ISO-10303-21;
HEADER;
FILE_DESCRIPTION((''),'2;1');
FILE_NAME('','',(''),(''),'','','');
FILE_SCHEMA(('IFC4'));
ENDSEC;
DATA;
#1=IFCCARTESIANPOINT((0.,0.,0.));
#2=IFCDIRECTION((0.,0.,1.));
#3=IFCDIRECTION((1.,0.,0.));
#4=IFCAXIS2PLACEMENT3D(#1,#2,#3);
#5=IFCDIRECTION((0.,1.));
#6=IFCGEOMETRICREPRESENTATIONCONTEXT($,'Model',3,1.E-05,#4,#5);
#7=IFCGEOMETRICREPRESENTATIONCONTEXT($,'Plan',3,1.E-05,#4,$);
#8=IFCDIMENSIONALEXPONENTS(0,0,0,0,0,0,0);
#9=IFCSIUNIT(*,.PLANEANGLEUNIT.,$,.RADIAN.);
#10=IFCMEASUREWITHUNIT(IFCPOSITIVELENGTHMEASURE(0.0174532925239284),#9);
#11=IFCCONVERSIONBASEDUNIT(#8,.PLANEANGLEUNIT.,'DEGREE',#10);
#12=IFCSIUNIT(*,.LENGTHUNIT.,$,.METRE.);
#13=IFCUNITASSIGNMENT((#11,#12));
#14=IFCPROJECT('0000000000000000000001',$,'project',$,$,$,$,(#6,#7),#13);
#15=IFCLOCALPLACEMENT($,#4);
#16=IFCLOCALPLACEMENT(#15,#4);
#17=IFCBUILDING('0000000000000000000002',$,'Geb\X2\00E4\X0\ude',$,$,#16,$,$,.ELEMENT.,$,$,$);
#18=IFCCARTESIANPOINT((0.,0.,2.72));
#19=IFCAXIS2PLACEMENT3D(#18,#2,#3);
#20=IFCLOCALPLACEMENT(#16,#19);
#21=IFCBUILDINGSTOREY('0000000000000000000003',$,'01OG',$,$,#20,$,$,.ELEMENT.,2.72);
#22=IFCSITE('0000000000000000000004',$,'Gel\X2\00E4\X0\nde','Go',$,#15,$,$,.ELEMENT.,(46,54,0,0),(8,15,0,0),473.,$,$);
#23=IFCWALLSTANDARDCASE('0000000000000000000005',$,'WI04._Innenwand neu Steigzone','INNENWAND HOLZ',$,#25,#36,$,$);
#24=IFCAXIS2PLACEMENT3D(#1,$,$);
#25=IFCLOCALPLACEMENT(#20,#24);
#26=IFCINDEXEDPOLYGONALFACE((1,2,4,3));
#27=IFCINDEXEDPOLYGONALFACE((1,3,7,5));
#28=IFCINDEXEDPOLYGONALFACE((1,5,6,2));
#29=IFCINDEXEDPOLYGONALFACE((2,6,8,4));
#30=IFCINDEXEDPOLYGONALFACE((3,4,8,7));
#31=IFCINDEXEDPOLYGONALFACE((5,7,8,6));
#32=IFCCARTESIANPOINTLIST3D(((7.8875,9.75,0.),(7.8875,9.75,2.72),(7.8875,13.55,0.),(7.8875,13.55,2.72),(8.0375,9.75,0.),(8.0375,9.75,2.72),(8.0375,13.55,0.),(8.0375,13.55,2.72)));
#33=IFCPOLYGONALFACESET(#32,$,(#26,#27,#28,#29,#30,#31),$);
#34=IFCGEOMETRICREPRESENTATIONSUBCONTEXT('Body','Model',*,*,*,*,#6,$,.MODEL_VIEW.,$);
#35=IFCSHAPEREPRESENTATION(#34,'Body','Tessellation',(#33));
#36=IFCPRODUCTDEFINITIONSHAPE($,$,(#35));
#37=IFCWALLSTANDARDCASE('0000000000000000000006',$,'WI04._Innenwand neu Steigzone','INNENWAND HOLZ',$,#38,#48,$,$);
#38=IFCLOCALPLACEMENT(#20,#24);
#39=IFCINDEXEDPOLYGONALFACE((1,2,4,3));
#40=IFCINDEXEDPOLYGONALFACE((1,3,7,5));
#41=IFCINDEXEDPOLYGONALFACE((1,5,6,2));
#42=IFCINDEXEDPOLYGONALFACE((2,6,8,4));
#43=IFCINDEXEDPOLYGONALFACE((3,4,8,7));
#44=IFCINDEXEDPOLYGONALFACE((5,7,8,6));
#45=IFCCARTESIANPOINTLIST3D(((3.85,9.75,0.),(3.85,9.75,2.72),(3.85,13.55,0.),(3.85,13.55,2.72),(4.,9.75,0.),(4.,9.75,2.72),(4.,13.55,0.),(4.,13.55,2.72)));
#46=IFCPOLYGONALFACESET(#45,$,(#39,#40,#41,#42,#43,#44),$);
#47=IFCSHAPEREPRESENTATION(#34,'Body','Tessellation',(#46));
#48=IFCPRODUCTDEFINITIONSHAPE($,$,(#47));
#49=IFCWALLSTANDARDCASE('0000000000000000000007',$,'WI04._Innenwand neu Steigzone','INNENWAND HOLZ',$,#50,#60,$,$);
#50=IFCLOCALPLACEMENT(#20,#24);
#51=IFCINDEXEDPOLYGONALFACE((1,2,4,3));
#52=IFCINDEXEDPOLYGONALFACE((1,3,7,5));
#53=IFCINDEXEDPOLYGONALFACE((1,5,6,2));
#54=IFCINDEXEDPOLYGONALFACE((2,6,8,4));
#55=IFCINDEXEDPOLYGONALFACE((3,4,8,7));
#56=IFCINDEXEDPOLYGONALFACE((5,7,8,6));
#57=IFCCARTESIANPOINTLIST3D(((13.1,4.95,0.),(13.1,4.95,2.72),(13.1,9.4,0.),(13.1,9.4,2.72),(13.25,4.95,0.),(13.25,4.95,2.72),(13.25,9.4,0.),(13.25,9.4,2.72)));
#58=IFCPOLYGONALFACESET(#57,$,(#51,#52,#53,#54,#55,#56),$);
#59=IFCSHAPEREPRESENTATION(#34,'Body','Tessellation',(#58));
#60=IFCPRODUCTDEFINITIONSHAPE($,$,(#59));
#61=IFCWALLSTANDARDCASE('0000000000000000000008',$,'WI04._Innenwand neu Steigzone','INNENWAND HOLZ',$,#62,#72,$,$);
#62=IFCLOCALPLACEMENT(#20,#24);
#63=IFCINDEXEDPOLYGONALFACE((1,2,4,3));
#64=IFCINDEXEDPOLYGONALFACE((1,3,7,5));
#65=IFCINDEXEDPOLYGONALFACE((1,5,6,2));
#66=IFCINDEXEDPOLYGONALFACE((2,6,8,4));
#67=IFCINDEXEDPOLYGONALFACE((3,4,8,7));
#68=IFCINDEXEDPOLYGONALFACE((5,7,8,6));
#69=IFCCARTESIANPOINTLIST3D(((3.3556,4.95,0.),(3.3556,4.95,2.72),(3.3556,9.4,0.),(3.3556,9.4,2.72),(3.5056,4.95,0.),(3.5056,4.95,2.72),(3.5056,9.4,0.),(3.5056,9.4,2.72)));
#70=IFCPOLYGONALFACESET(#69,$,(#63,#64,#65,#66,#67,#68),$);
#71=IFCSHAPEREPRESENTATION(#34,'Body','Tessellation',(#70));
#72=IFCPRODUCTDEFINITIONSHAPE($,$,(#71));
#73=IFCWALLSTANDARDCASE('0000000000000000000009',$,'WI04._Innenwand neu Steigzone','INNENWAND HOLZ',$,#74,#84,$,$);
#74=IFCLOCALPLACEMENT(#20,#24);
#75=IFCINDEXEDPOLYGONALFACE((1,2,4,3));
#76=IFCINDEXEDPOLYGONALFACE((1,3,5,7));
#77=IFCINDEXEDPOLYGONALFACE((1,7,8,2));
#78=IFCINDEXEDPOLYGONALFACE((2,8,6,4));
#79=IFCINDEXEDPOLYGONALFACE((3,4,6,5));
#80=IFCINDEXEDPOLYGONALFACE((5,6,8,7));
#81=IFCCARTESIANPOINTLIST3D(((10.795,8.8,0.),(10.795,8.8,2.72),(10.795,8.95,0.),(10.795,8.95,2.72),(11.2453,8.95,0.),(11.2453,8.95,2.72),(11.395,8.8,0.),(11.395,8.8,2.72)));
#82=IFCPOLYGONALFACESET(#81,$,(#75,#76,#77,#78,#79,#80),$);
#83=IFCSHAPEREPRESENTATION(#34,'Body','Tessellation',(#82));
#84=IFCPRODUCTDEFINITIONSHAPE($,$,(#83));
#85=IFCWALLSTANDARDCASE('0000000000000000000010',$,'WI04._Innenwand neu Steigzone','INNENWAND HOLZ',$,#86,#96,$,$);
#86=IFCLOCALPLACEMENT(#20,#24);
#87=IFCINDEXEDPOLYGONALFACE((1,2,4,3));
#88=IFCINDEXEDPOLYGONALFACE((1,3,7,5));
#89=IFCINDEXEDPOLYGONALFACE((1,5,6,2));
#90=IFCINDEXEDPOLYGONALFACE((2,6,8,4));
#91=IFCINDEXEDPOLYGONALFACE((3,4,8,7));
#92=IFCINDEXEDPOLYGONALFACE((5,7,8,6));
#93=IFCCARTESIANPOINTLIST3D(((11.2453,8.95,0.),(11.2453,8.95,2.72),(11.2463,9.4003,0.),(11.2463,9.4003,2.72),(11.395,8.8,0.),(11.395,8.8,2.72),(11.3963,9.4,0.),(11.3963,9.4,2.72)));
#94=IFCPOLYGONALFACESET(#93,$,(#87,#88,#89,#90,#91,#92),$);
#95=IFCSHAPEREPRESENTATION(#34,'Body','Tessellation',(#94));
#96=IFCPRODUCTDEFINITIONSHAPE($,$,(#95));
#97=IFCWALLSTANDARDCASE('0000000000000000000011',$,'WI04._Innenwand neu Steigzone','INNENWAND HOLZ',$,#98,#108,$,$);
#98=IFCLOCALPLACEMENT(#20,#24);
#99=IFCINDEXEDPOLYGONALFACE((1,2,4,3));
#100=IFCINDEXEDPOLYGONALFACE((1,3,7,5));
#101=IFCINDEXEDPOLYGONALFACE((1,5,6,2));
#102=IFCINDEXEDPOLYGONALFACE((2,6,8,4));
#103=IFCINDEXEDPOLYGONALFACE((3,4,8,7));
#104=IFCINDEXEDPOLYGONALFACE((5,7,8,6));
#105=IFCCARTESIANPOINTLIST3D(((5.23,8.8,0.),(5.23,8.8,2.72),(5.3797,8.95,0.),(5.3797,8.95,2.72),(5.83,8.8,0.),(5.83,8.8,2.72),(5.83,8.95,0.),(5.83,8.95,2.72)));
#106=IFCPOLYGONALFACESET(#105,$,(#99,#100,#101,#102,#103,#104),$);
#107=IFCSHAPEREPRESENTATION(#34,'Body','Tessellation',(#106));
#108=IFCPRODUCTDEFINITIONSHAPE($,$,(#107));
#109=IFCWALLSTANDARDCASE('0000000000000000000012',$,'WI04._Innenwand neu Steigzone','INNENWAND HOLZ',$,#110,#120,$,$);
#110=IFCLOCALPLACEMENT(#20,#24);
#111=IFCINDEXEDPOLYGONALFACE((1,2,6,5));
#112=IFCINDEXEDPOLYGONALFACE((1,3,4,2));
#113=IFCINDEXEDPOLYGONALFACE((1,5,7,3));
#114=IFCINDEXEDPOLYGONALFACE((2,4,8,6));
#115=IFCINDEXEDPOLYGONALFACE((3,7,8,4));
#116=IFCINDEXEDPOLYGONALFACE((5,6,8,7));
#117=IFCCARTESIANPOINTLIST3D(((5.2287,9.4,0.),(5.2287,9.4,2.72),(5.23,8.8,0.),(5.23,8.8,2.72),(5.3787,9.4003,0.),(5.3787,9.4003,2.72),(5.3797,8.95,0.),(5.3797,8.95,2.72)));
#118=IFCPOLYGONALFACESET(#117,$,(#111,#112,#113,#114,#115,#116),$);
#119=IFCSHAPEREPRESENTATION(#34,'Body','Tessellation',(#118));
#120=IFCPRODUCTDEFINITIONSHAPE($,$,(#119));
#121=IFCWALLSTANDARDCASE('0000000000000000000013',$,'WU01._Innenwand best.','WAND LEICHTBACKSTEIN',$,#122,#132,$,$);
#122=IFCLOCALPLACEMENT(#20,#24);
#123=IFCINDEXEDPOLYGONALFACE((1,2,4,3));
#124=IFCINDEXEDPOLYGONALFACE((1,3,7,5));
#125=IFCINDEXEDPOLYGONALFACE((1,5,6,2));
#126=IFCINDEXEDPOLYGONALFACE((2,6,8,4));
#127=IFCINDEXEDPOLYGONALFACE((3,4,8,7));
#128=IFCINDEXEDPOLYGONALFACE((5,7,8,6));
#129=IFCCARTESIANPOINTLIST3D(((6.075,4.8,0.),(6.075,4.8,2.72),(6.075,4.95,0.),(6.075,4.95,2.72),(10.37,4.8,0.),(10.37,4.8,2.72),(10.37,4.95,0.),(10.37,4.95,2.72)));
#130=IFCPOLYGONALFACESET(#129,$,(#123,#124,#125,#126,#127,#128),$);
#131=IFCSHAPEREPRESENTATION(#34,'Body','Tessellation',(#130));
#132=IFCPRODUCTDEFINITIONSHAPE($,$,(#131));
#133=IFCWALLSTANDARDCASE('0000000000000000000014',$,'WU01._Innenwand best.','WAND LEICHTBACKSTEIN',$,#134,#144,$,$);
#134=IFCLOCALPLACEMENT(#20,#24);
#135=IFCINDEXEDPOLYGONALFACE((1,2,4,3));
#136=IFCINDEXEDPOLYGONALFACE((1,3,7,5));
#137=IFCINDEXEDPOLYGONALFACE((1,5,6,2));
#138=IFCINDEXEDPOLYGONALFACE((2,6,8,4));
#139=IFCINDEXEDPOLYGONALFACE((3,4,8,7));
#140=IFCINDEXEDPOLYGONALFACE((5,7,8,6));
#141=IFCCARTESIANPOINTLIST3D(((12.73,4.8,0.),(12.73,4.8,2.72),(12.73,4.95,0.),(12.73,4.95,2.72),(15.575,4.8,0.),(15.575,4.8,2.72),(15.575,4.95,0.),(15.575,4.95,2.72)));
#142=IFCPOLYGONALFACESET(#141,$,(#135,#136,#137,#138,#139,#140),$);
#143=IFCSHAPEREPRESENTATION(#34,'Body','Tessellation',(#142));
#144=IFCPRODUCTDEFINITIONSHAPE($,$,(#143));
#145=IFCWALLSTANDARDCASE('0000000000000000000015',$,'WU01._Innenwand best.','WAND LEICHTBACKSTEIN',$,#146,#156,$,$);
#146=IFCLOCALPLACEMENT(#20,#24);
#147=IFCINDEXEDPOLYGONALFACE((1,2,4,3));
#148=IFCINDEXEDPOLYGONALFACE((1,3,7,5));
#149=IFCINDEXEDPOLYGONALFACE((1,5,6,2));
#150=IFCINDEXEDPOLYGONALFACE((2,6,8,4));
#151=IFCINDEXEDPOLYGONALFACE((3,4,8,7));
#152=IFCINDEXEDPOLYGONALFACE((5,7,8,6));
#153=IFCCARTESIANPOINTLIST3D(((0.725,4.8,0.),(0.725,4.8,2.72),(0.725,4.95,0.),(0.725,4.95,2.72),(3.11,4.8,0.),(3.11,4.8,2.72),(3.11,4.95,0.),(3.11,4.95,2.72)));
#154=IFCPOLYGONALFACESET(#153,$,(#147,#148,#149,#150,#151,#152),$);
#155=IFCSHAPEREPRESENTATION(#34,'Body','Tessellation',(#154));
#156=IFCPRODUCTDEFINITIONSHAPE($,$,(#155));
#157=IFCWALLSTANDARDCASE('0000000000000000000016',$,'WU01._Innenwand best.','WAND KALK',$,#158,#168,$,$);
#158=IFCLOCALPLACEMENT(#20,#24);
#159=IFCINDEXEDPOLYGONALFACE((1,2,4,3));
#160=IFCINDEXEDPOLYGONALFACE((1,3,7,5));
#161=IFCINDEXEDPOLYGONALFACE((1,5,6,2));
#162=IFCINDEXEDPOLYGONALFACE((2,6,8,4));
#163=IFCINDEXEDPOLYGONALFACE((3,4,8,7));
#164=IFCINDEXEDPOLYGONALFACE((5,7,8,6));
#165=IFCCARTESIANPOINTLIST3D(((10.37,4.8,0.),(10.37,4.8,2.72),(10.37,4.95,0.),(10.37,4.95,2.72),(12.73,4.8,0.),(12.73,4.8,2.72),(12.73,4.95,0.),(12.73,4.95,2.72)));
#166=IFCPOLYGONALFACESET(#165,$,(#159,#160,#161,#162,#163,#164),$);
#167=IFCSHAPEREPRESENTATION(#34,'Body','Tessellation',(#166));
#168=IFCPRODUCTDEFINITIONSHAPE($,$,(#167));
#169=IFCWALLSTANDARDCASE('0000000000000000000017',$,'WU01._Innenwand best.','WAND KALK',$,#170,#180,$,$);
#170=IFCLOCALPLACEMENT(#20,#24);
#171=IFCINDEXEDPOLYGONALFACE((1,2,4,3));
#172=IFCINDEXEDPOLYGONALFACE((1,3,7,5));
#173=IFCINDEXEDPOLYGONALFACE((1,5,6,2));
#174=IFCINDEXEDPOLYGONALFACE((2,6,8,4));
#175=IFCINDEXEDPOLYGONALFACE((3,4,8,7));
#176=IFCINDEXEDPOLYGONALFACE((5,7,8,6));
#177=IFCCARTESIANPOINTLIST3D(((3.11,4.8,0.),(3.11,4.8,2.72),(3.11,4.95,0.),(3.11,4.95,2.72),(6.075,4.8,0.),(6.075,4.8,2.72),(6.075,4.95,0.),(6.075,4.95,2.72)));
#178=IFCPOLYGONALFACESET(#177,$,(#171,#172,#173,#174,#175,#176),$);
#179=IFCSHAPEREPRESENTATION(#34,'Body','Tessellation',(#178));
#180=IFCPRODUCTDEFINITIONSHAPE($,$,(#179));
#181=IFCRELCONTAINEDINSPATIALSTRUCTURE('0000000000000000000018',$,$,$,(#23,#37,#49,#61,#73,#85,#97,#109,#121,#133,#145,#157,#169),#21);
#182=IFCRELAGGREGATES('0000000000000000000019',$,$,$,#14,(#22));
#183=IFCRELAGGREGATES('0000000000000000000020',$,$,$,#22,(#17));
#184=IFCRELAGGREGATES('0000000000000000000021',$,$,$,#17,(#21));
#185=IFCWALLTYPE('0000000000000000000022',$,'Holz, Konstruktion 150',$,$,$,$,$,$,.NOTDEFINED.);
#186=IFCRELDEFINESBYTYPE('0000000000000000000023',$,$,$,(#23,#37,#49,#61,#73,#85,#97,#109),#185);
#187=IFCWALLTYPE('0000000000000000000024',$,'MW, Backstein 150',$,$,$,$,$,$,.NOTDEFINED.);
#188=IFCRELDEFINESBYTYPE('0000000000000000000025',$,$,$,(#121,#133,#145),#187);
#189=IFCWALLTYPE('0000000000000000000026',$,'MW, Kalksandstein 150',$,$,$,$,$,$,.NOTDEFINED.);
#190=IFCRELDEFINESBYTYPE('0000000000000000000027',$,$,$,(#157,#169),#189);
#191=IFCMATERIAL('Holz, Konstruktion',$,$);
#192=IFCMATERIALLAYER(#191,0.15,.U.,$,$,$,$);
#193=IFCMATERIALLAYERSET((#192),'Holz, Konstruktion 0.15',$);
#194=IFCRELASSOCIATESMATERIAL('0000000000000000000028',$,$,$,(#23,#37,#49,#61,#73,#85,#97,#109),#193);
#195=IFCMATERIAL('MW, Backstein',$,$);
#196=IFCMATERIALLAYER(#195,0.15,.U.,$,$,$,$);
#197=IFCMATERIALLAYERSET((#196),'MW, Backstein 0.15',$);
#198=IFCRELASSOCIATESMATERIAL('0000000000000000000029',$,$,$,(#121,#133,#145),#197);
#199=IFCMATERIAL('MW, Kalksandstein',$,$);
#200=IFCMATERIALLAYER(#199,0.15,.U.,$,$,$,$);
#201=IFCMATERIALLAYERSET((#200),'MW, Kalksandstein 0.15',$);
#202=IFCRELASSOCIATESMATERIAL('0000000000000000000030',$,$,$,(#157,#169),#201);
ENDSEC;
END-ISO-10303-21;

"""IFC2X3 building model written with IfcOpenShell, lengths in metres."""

from ifc_helpers import new_model, entity, si_unit, converted_unit, direction, frame, origin_with_axes, place, context, subcontext, project, spatial, polyline, outline, extrude, material, layer, layer_set, layer_usage, type_object, element, save


model = new_model("IFC2X3")

# Units and contexts
model_context = context("Model", 3, precision=1e-05, world=origin_with_axes(), true_north=direction((0.0, 1.0)))
plan_context = context("Plan", 3, precision=1e-05, world=origin_with_axes())
body_context = subcontext(model_context, "Body", "Model", "MODEL_VIEW")
ifc_project = project(units=[converted_unit("PLANEANGLEUNIT", "DEGREE", entity("IfcPositiveLengthMeasure", 0.0174532925239284), si_unit("PLANEANGLEUNIT", "RADIAN"), dimensions=[0, 0, 0, 0, 0, 0, 0]), si_unit("LENGTHUNIT", "METRE")], contexts=[model_context, plan_context])

# Site, building, storey
site_placement = place(None, origin_with_axes())
site = spatial("IfcSite", under=ifc_project, at=site_placement, Name="Gelände", Description="Go", CompositionType="ELEMENT", RefLatitude=(46, 54, 0, 0), RefLongitude=(8, 15, 0, 0), RefElevation=473.0)
building_placement = place(site_placement, origin_with_axes())
building = spatial("IfcBuilding", under=site, at=building_placement, Name="Gebäude", CompositionType="ELEMENT")
storey_placement = place(building_placement, frame((0.0, 0.0, 2.72), z_axis=(0.0, 0.0, 1.0), x_axis=(1.0, 0.0, 0.0)))
storey = spatial("IfcBuildingStorey", under=building, at=storey_placement, Name="01OG", CompositionType="ELEMENT", Elevation=2.72)

# Shared definitions
ifc_material_1 = material(Name="Holz, Konstruktion")

# Walls
ifc_layer_1 = layer(ifc_material_1, 0.15, ventilated="UNKNOWN")
ifc_layer_set_1 = layer_set([ifc_layer_1], Name="Holz, Konstruktion 0.15")
wall_type_1 = type_object("IfcWallType", Name="Holz, Konstruktion 150", PredefinedType="NOTDEFINED")
ifc_layer_usage_1 = layer_usage(ifc_layer_set_1, "AXIS2", "POSITIVE", 0.0)
wall_1_placement = place(storey_placement, frame((7.8875, 13.55, 0.0), z_axis=(0.0, 0.0, 1.0), x_axis=(0.0, -1.0, 0.0)))
element("IfcWallStandardCase", 1, at=wall_1_placement, inside=storey, type_object=wall_type_1, material=ifc_layer_usage_1, Name="WI04._Innenwand neu Steigzone", Description="INNENWAND HOLZ", context=body_context, shape_type="SweptSolid", body=[
    extrude(outline(polyline([(0.0, 0.0), (3.8, 0.0), (3.8, 0.15), (0.0, 0.15), (0.0, 0.0)])), origin_with_axes(), (0.0, 0.0, 1.0), 2.72),
])
ifc_layer_usage_2 = layer_usage(ifc_layer_set_1, "AXIS2", "NEGATIVE", 0.0)
wall_2_placement = place(storey_placement, frame((4.0, 13.55, 0.0), z_axis=(0.0, 0.0, 1.0), x_axis=(0.0, -1.0, 0.0)))
element("IfcWallStandardCase", 2, at=wall_2_placement, inside=storey, type_object=wall_type_1, material=ifc_layer_usage_2, Name="WI04._Innenwand neu Steigzone", Description="INNENWAND HOLZ", context=body_context, shape_type="SweptSolid", body=[
    extrude(outline(polyline([(0.0, -0.15), (3.8, -0.15), (3.8, 0.0), (0.0, 0.0), (0.0, -0.15)])), origin_with_axes(), (0.0, 0.0, 1.0), 2.72),
])
ifc_layer_usage_3 = layer_usage(ifc_layer_set_1, "AXIS2", "POSITIVE", 0.0)
wall_3_placement = place(storey_placement, frame((13.1, 9.4, 0.0), z_axis=(0.0, 0.0, 1.0), x_axis=(0.0, -1.0, 0.0)))
element("IfcWallStandardCase", 3, at=wall_3_placement, inside=storey, type_object=wall_type_1, material=ifc_layer_usage_3, Name="WI04._Innenwand neu Steigzone", Description="INNENWAND HOLZ", context=body_context, shape_type="SweptSolid", body=[
    extrude(outline(polyline([(0.0, 0.0), (4.45, 0.0), (4.45, 0.15), (0.0, 0.15), (0.0, 0.0)])), origin_with_axes(), (0.0, 0.0, 1.0), 2.72),
])
ifc_layer_usage_4 = layer_usage(ifc_layer_set_1, "AXIS2", "NEGATIVE", 0.0)
wall_4_placement = place(storey_placement, frame((3.5056, 9.4, 0.0), z_axis=(0.0, 0.0, 1.0), x_axis=(0.0, -1.0, 0.0)))
element("IfcWallStandardCase", 4, at=wall_4_placement, inside=storey, type_object=wall_type_1, material=ifc_layer_usage_4, Name="WI04._Innenwand neu Steigzone", Description="INNENWAND HOLZ", context=body_context, shape_type="SweptSolid", body=[
    extrude(outline(polyline([(0.0, -0.15), (4.45, -0.15), (4.45, 0.0), (0.0, 0.0), (0.0, -0.15)])), origin_with_axes(), (0.0, 0.0, 1.0), 2.72),
])
ifc_layer_usage_5 = layer_usage(ifc_layer_set_1, "AXIS2", "NEGATIVE", 0.0)
wall_5_placement = place(storey_placement, frame((11.395, 8.8, 0.0), z_axis=(0.0, 0.0, 1.0), x_axis=(-1.0, 0.0, 0.0)))
element("IfcWallStandardCase", 5, at=wall_5_placement, inside=storey, type_object=wall_type_1, material=ifc_layer_usage_5, Name="WI04._Innenwand neu Steigzone", Description="INNENWAND HOLZ", context=body_context, shape_type="SweptSolid", body=[
    extrude(outline(polyline([(0.1497, -0.15), (0.6, -0.15), (0.6, 0.0), (0.0, 0.0), (0.1497, -0.15)])), origin_with_axes(), (0.0, 0.0, 1.0), 2.72),
])
ifc_layer_usage_6 = layer_usage(ifc_layer_set_1, "AXIS2", "NEGATIVE", 0.0)
wall_6_placement = place(storey_placement, frame((11.3963, 9.4, 0.0), z_axis=(0.0, 0.0, 1.0), x_axis=(-0.002118, -0.999998, 0.0)))
element("IfcWallStandardCase", 6, at=wall_6_placement, inside=storey, type_object=wall_type_1, material=ifc_layer_usage_6, Name="WI04._Innenwand neu Steigzone", Description="INNENWAND HOLZ", context=body_context, shape_type="SweptSolid", body=[
    extrude(outline(polyline([(0.0, -0.15), (0.4503, -0.15), (0.6, 0.0), (0.0, 0.0), (0.0, -0.15)])), origin_with_axes(), (0.0, 0.0, 1.0), 2.72),
])
ifc_layer_usage_7 = layer_usage(ifc_layer_set_1, "AXIS2", "POSITIVE", 0.0)
wall_7_placement = place(storey_placement, frame((5.23, 8.8, 0.0), z_axis=(0.0, 0.0, 1.0), x_axis=(1.0, 0.0, 0.0)))
element("IfcWallStandardCase", 7, at=wall_7_placement, inside=storey, type_object=wall_type_1, material=ifc_layer_usage_7, Name="WI04._Innenwand neu Steigzone", Description="INNENWAND HOLZ", context=body_context, shape_type="SweptSolid", body=[
    extrude(outline(polyline([(0.0, 0.0), (0.6, 0.0), (0.6, 0.15), (0.1497, 0.15), (0.0, 0.0)])), origin_with_axes(), (0.0, 0.0, 1.0), 2.72),
])
ifc_layer_usage_8 = layer_usage(ifc_layer_set_1, "AXIS2", "POSITIVE", 0.0)
wall_8_placement = place(storey_placement, frame((5.2287, 9.4, 0.0), z_axis=(0.0, 0.0, 1.0), x_axis=(0.002118, -0.999998, 0.0)))
element("IfcWallStandardCase", 8, at=wall_8_placement, inside=storey, type_object=wall_type_1, material=ifc_layer_usage_8, Name="WI04._Innenwand neu Steigzone", Description="INNENWAND HOLZ", context=body_context, shape_type="SweptSolid", body=[
    extrude(outline(polyline([(0.0, 0.0), (0.6, 0.0), (0.4503, 0.15), (0.0, 0.15), (0.0, 0.0)])), origin_with_axes(), (0.0, 0.0, 1.0), 2.72),
])
ifc_material_2 = material(Name="MW, Backstein")
ifc_layer_2 = layer(ifc_material_2, 0.15, ventilated="UNKNOWN")
ifc_layer_set_2 = layer_set([ifc_layer_2], Name="MW, Backstein 0.15")
ifc_layer_usage_9 = layer_usage(ifc_layer_set_2, "AXIS2", "POSITIVE", -0.15)
wall_type_2 = type_object("IfcWallType", Name="MW, Backstein 150", PredefinedType="NOTDEFINED")
wall_9_placement = place(storey_placement, frame((6.075, 4.95, 0.0), z_axis=(0.0, 0.0, 1.0), x_axis=(1.0, 0.0, 0.0)))
element("IfcWallStandardCase", 9, at=wall_9_placement, inside=storey, type_object=wall_type_2, material=ifc_layer_usage_9, Name="WU01._Innenwand best.", Description="WAND LEICHTBACKSTEIN", context=body_context, shape_type="SweptSolid", body=[
    extrude(outline(polyline([(0.0, -0.15), (4.295, -0.15), (4.295, 0.0), (0.0, 0.0), (0.0, -0.15)])), origin_with_axes(), (0.0, 0.0, 1.0), 2.72),
])
ifc_layer_usage_10 = layer_usage(ifc_layer_set_2, "AXIS2", "POSITIVE", -0.15)
wall_10_placement = place(storey_placement, frame((12.73, 4.95, 0.0), z_axis=(0.0, 0.0, 1.0), x_axis=(1.0, 0.0, 0.0)))
element("IfcWallStandardCase", 10, at=wall_10_placement, inside=storey, type_object=wall_type_2, material=ifc_layer_usage_10, Name="WU01._Innenwand best.", Description="WAND LEICHTBACKSTEIN", context=body_context, shape_type="SweptSolid", body=[
    extrude(outline(polyline([(0.0, -0.15), (2.845, -0.15), (2.845, 0.0), (0.0, 0.0), (0.0, -0.15)])), origin_with_axes(), (0.0, 0.0, 1.0), 2.72),
])
ifc_layer_usage_11 = layer_usage(ifc_layer_set_2, "AXIS2", "POSITIVE", -0.15)
wall_11_placement = place(storey_placement, frame((0.725, 4.95, 0.0), z_axis=(0.0, 0.0, 1.0), x_axis=(1.0, 0.0, 0.0)))
element("IfcWallStandardCase", 11, at=wall_11_placement, inside=storey, type_object=wall_type_2, material=ifc_layer_usage_11, Name="WU01._Innenwand best.", Description="WAND LEICHTBACKSTEIN", context=body_context, shape_type="SweptSolid", body=[
    extrude(outline(polyline([(0.0, -0.15), (2.385, -0.15), (2.385, 0.0), (0.0, 0.0), (0.0, -0.15)])), origin_with_axes(), (0.0, 0.0, 1.0), 2.72),
])
ifc_material_3 = material(Name="MW, Kalksandstein")
ifc_layer_3 = layer(ifc_material_3, 0.15, ventilated="UNKNOWN")
ifc_layer_set_3 = layer_set([ifc_layer_3], Name="MW, Kalksandstein 0.15")
ifc_layer_usage_12 = layer_usage(ifc_layer_set_3, "AXIS2", "POSITIVE", -0.15)
wall_type_3 = type_object("IfcWallType", Name="MW, Kalksandstein 150", PredefinedType="NOTDEFINED")
wall_12_placement = place(storey_placement, frame((10.37, 4.95, 0.0), z_axis=(0.0, 0.0, 1.0), x_axis=(1.0, 0.0, 0.0)))
element("IfcWallStandardCase", 12, at=wall_12_placement, inside=storey, type_object=wall_type_3, material=ifc_layer_usage_12, Name="WU01._Innenwand best.", Description="WAND KALK", context=body_context, shape_type="SweptSolid", body=[
    extrude(outline(polyline([(0.0, -0.15), (2.36, -0.15), (2.36, 0.0), (0.0, 0.0), (0.0, -0.15)])), origin_with_axes(), (0.0, 0.0, 1.0), 2.72),
])
ifc_layer_usage_13 = layer_usage(ifc_layer_set_3, "AXIS2", "POSITIVE", -0.15)
wall_13_placement = place(storey_placement, frame((3.11, 4.95, 0.0), z_axis=(0.0, 0.0, 1.0), x_axis=(1.0, 0.0, 0.0)))
element("IfcWallStandardCase", 13, at=wall_13_placement, inside=storey, type_object=wall_type_3, material=ifc_layer_usage_13, Name="WU01._Innenwand best.", Description="WAND KALK", context=body_context, shape_type="SweptSolid", body=[
    extrude(outline(polyline([(0.0, -0.15), (2.965, -0.15), (2.965, 0.0), (0.0, 0.0), (0.0, -0.15)])), origin_with_axes(), (0.0, 0.0, 1.0), 2.72),
])

save(model, "model.ifc")
